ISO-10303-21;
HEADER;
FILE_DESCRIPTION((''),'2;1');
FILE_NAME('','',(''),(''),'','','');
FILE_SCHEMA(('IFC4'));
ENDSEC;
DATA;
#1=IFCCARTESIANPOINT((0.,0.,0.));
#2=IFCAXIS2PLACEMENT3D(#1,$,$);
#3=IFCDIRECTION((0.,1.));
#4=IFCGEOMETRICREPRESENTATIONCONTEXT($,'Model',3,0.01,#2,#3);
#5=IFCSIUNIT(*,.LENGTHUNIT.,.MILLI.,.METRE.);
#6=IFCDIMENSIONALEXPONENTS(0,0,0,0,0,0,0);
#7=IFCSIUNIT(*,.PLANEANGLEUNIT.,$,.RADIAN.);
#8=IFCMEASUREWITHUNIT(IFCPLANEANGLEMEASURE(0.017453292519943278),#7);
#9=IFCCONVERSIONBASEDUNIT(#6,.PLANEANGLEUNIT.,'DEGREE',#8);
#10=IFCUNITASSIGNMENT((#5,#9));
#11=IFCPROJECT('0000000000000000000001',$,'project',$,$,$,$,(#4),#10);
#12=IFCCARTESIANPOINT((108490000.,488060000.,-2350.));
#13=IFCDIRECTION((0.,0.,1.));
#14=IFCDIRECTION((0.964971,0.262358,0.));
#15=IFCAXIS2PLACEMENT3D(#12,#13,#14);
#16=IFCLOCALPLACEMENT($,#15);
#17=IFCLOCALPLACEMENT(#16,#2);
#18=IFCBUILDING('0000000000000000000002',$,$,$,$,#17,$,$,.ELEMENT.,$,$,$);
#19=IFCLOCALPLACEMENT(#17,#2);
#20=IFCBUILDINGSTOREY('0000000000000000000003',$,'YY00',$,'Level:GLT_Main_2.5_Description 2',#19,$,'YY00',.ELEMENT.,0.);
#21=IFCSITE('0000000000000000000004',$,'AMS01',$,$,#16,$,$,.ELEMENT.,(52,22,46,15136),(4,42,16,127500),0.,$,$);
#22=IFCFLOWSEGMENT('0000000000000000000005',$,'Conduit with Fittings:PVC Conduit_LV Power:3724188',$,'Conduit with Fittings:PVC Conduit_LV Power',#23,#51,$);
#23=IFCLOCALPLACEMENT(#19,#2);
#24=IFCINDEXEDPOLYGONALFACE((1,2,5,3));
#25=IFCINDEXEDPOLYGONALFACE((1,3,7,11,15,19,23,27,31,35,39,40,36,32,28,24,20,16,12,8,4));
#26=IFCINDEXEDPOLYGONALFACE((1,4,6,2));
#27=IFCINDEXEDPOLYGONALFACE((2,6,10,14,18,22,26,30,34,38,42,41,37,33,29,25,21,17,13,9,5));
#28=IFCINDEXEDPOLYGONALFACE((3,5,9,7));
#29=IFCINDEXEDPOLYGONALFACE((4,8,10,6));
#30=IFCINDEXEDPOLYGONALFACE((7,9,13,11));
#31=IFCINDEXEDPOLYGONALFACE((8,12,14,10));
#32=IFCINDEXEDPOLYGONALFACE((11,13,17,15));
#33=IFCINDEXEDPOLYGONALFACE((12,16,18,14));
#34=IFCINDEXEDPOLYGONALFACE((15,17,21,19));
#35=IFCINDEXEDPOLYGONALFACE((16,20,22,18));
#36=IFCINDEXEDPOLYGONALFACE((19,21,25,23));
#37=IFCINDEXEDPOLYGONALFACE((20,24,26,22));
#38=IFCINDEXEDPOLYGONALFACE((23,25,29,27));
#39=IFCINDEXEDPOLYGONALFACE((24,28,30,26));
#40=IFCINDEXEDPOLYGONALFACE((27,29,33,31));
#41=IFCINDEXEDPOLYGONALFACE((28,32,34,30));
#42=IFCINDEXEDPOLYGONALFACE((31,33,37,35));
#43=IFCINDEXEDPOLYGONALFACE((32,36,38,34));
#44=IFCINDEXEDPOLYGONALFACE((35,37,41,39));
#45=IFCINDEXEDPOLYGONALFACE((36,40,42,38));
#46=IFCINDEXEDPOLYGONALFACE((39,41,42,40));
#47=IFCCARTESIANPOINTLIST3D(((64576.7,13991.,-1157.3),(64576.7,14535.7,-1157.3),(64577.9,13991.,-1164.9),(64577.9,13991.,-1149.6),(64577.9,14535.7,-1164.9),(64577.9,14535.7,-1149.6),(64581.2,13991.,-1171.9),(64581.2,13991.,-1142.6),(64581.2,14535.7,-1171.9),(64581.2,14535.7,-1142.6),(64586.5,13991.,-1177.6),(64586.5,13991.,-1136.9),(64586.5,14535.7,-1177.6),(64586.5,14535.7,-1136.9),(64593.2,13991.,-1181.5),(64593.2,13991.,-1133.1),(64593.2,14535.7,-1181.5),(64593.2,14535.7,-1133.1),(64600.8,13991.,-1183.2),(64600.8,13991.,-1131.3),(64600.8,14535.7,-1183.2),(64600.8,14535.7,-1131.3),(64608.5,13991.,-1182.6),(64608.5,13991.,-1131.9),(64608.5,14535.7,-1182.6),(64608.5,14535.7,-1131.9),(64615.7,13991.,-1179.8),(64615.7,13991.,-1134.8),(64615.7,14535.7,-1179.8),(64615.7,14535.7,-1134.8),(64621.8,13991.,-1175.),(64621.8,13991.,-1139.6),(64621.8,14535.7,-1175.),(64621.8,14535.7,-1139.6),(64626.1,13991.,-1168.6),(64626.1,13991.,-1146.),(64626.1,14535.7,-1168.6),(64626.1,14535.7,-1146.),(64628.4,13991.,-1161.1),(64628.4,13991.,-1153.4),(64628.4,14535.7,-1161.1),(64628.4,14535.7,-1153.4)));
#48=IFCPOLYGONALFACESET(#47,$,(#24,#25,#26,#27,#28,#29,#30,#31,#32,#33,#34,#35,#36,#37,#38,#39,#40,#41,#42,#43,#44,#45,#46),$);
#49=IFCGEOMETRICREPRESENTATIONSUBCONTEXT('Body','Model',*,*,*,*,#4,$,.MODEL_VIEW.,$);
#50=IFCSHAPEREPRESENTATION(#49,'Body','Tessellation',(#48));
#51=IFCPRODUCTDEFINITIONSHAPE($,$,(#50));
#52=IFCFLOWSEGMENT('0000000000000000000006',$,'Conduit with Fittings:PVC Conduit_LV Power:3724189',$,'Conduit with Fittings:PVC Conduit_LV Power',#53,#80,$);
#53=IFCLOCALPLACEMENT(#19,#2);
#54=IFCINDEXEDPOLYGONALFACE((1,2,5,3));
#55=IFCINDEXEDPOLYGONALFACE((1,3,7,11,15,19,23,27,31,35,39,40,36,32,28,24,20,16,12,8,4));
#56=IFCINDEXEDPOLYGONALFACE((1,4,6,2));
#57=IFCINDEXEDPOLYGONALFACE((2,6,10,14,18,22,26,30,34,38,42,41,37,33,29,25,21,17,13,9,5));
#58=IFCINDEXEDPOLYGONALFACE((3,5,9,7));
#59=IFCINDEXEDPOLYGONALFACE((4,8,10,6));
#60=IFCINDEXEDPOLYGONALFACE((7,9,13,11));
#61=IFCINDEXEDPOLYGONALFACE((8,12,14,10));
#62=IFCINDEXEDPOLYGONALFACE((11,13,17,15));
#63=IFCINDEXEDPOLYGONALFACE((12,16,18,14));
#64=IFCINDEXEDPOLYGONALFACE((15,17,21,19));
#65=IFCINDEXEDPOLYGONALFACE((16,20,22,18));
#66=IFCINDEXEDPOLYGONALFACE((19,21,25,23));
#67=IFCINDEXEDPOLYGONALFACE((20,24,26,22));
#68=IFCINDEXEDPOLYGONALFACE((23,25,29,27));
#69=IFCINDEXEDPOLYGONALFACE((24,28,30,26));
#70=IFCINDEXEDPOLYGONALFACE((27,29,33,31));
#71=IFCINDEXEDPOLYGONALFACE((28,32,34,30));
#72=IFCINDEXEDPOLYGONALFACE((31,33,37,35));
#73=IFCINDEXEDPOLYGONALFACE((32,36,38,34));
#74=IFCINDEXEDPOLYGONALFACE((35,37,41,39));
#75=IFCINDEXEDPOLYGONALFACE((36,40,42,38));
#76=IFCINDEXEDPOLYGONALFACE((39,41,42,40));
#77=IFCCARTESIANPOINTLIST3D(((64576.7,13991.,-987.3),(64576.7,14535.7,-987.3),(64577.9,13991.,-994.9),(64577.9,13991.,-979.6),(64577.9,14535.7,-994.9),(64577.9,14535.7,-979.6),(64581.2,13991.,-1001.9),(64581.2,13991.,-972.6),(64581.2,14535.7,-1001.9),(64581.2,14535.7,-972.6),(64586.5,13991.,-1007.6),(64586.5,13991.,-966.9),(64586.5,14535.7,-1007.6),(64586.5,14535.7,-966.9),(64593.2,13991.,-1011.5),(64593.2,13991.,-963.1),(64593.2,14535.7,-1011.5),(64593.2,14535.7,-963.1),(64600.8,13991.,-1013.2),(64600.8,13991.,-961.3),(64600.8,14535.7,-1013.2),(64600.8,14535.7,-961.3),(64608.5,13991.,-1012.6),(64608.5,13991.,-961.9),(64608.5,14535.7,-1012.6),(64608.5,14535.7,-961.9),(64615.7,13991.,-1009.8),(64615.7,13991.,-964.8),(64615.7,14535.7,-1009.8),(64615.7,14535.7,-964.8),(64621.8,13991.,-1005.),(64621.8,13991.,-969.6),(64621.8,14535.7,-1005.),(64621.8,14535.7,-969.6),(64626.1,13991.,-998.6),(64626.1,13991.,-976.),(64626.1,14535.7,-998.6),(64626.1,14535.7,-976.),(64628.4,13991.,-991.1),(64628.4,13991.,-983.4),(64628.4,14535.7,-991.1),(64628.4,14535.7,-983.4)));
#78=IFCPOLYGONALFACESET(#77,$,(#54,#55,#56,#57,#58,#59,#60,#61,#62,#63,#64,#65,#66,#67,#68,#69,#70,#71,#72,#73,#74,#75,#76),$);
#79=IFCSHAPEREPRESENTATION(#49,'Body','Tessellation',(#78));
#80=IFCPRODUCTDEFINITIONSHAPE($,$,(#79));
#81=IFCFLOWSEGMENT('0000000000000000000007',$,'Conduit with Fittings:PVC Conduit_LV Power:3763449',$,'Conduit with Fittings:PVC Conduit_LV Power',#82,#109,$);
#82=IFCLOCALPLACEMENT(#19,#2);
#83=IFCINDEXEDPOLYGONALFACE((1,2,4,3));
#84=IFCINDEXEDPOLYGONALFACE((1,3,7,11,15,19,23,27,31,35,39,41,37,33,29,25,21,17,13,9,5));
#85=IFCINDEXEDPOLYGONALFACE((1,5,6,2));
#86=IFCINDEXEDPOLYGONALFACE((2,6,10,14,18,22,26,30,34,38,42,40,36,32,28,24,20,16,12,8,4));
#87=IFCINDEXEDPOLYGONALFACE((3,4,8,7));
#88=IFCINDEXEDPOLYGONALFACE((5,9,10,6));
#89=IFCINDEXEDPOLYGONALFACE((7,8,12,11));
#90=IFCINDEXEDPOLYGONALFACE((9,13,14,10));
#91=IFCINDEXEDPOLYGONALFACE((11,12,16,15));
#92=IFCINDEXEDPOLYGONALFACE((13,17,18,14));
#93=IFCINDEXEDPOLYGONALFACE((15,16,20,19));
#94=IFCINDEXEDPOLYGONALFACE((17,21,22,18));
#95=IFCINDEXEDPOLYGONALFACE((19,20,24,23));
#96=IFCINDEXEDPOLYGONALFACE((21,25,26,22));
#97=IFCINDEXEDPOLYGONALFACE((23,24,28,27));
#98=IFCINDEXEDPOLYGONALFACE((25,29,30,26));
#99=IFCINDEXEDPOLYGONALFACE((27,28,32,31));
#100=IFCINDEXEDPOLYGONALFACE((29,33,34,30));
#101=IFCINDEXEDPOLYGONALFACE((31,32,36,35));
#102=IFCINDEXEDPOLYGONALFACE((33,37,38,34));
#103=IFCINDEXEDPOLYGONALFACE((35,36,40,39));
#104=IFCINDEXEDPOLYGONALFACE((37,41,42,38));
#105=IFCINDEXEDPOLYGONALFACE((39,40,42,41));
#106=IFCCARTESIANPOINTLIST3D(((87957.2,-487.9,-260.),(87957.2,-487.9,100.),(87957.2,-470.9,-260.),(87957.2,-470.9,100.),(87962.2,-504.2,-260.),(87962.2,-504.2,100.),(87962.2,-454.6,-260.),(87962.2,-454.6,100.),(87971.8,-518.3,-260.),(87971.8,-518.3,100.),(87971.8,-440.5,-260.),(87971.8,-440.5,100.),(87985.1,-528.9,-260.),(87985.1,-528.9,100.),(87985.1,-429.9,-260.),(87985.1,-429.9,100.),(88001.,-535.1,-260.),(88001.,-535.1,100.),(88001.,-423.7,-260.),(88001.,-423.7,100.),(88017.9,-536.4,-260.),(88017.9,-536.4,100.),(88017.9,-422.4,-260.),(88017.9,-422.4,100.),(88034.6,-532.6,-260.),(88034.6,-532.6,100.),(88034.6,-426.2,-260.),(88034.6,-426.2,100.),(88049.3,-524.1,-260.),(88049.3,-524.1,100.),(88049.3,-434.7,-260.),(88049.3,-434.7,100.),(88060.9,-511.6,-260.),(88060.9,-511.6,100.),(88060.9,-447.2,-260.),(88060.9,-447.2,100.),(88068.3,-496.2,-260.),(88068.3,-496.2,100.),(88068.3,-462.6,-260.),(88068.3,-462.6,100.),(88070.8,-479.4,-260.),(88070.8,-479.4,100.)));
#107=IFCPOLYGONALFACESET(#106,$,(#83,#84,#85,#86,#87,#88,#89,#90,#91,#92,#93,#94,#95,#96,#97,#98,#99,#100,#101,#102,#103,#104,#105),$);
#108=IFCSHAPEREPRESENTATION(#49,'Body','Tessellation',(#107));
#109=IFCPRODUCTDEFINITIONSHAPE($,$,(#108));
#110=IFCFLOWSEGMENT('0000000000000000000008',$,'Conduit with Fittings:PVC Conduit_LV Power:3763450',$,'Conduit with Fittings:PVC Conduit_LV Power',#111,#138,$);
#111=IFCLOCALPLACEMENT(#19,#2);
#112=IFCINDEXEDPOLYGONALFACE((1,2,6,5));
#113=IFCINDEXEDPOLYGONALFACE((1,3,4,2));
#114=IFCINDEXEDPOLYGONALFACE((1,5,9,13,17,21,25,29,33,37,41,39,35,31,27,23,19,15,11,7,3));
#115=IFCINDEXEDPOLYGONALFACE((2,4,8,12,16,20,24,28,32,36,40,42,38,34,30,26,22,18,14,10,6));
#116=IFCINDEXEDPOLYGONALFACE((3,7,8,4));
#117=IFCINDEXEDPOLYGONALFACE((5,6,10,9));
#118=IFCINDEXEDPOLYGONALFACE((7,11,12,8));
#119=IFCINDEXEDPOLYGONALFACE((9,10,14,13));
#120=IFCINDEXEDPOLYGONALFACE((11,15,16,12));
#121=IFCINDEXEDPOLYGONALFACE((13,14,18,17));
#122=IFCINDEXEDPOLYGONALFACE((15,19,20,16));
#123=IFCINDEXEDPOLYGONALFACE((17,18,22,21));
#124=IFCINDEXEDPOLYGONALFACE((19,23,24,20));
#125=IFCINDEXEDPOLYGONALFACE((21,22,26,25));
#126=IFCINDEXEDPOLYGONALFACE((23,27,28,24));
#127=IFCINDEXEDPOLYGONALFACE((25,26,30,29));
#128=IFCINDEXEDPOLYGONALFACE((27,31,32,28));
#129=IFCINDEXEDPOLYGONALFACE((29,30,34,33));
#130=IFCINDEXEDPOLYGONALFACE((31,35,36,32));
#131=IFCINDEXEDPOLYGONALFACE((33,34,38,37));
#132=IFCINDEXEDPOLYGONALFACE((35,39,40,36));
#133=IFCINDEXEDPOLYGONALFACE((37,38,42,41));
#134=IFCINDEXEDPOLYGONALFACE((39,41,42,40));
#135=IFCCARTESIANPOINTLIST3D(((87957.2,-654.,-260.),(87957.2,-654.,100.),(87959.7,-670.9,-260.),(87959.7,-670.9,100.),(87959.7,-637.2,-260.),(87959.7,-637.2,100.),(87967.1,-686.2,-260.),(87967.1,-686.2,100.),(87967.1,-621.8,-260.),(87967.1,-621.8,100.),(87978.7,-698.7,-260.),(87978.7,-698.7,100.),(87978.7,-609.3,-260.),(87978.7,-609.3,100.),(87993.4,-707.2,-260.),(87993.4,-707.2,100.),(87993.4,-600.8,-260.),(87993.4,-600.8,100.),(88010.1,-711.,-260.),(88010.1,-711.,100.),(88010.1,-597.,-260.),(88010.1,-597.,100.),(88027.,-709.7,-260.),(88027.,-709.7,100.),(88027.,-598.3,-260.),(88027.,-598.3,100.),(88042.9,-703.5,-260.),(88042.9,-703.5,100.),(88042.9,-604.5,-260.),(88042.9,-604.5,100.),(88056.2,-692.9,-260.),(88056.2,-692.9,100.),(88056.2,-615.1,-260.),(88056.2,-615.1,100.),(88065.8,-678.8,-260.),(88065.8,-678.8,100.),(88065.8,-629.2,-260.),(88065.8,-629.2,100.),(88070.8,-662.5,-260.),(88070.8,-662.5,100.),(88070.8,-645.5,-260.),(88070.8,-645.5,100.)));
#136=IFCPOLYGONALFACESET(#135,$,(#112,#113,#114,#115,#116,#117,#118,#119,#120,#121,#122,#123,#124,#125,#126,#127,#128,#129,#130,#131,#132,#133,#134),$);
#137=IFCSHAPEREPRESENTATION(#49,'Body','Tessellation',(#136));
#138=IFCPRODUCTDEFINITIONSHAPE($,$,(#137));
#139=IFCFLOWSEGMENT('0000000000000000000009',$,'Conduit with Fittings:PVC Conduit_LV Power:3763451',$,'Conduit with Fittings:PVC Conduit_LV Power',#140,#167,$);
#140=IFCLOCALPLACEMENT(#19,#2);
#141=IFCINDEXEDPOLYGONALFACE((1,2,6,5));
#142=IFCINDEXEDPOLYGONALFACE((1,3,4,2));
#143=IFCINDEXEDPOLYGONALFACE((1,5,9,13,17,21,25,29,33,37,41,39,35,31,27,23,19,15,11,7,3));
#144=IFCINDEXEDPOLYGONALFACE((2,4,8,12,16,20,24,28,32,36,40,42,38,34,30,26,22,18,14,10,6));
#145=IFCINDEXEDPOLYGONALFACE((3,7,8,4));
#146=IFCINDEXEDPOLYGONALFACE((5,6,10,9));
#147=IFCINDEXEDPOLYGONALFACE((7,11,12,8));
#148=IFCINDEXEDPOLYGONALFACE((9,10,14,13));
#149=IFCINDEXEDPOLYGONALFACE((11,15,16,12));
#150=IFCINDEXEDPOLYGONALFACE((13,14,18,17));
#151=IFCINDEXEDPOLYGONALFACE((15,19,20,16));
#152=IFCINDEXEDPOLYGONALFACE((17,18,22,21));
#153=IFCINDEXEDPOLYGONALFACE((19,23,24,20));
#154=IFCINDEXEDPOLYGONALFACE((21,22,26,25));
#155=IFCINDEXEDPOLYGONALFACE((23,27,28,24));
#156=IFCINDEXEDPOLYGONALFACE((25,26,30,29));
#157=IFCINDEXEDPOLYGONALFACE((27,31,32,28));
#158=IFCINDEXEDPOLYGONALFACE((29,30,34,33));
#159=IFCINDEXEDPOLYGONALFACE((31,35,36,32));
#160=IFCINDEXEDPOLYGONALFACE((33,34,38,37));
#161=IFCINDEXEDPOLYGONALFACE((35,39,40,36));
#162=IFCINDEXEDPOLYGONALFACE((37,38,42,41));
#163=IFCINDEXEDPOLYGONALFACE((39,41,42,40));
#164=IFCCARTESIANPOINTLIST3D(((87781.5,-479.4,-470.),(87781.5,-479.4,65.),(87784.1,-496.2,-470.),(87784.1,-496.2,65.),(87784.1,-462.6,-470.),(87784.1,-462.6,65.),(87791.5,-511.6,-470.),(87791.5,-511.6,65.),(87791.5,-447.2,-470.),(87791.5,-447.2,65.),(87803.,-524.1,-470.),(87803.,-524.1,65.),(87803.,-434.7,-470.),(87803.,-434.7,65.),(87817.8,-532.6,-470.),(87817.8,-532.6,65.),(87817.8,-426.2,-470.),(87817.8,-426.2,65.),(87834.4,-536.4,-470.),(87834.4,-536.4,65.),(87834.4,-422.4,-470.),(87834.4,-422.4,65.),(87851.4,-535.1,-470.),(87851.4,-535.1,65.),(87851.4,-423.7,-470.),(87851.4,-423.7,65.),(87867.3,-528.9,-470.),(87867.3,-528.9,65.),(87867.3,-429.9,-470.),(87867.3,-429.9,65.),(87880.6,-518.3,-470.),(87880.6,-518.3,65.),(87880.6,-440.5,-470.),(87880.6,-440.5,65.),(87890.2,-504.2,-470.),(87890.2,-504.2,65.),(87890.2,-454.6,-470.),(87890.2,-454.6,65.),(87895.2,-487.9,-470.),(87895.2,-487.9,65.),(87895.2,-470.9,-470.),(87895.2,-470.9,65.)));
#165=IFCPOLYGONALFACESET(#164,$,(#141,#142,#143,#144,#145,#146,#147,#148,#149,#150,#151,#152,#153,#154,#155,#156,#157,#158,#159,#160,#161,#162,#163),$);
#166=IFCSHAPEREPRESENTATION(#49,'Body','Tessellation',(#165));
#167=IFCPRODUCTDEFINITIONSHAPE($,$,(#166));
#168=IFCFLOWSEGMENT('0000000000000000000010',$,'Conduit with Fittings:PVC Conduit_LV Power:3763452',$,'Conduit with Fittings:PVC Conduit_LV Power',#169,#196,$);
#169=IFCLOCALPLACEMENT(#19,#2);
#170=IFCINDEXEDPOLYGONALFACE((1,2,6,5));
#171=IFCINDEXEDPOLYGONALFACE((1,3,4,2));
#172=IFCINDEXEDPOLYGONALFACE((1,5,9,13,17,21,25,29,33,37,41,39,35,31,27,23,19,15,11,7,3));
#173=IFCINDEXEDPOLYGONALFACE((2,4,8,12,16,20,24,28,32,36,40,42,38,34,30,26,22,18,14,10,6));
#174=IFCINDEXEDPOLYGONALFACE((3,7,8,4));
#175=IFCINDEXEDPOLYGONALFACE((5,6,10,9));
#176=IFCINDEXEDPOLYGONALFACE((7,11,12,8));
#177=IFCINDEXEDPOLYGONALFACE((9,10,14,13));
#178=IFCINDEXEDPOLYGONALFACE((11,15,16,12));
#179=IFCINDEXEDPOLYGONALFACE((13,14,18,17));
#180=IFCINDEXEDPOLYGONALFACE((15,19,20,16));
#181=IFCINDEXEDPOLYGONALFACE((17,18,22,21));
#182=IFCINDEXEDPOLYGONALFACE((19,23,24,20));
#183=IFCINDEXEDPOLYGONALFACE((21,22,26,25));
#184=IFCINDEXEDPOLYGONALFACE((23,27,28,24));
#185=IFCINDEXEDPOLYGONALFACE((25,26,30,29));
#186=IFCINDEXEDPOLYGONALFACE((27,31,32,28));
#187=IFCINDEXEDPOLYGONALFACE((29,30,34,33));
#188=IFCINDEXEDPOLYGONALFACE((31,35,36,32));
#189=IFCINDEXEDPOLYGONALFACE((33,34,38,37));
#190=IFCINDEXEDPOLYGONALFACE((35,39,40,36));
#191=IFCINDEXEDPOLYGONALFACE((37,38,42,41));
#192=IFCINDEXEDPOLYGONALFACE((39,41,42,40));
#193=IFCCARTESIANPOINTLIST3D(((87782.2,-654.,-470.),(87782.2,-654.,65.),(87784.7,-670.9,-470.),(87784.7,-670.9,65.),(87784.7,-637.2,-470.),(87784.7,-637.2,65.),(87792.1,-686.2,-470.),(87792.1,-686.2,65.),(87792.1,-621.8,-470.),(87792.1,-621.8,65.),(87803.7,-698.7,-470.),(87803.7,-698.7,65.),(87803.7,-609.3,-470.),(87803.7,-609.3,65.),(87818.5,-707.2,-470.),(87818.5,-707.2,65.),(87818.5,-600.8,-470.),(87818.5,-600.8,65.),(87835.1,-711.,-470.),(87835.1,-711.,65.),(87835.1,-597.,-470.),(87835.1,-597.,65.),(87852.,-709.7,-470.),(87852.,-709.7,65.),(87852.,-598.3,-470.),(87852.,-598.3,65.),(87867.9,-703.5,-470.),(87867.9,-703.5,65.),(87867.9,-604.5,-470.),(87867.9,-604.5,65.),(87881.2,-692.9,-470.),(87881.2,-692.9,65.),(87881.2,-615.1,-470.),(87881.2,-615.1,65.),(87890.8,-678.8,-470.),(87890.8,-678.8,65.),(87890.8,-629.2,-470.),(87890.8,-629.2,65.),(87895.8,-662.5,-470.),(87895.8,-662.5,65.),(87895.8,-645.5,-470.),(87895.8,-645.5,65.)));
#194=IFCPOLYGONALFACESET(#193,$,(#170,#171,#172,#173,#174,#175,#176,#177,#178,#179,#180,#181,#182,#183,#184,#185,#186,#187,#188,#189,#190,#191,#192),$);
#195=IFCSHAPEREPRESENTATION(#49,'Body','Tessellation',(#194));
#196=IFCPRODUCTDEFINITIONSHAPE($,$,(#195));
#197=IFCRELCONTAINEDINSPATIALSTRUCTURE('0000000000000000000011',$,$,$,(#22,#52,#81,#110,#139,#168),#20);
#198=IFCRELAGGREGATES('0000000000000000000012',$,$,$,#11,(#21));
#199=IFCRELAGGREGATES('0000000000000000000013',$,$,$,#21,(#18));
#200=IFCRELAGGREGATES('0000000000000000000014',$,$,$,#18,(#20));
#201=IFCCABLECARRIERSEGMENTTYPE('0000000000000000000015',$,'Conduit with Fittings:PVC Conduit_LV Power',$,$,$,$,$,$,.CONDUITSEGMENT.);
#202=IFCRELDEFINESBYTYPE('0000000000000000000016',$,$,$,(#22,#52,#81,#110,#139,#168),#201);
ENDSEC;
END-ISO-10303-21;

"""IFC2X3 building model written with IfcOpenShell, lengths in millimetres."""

from ifc_helpers import new_model, entity, si_unit, converted_unit, direction, frame, frame_2d, origin, origin_2d_with_axis, place, context, subcontext, project, spatial, circle, extrude, type_object, element, save


model = new_model("IFC2X3")

# Units and contexts
model_context = context("Model", 3, precision=0.01, world=origin(), true_north=direction((0.0, 1.0)))
body_context = subcontext(model_context, "Body", "Model", "MODEL_VIEW")
ifc_project = project(units=[si_unit("LENGTHUNIT", "METRE", prefix="MILLI"), converted_unit("PLANEANGLEUNIT", "DEGREE", entity("IfcPlaneAngleMeasure", 0.017453292519943278), si_unit("PLANEANGLEUNIT", "RADIAN"), dimensions=[0, 0, 0, 0, 0, 0, 0])], contexts=[model_context])

# Site, building, storey
site_placement = place(None, frame((108490000.0, 488060000.0, -2350.0), z_axis=(0.0, 0.0, 1.0), x_axis=(0.964971, 0.262358, 0.0)))
site = spatial("IfcSite", under=ifc_project, at=site_placement, Name="AMS01", CompositionType="ELEMENT", RefLatitude=(52, 22, 46, 15136), RefLongitude=(4, 42, 16, 127500), RefElevation=0.0)
building_placement = place(site_placement, origin())
building = spatial("IfcBuilding", under=site, at=building_placement, CompositionType="ELEMENT")
storey_placement = place(building_placement, origin())
storey = spatial("IfcBuildingStorey", under=building, at=storey_placement, Name="YY00", ObjectType="Level:GLT_Main_2.5_Description 2", LongName="YY00", CompositionType="ELEMENT", Elevation=0.0)

# Flow segments
cable_carrier_segment_type = type_object("IfcCableCarrierSegmentType", Name="Conduit with Fittings:PVC Conduit_LV Power", PredefinedType="CONDUITSEGMENT")
flow_segment_1_placement = place(storey_placement, origin())
element("IfcFlowSegment", 1, at=flow_segment_1_placement, inside=storey, type_object=cable_carrier_segment_type, Name="Conduit with Fittings:PVC Conduit_LV Power:3724188", ObjectType="Conduit with Fittings:PVC Conduit_LV Power", context=body_context, shape_type="SweptSolid", body=[
    extrude(circle(Radius=26.0, at=frame_2d((0.0, 0.0), x_axis=(1.0, 0.0))), frame((64602.7, 13991.0, -1157.3), z_axis=(0.0, 1.0, 0.0), x_axis=(-1.0, 0.0, 0.0)), (0.0, 0.0, 1.0), 544.6),
])
flow_segment_2_placement = place(storey_placement, origin())
element("IfcFlowSegment", 2, at=flow_segment_2_placement, inside=storey, type_object=cable_carrier_segment_type, Name="Conduit with Fittings:PVC Conduit_LV Power:3724189", ObjectType="Conduit with Fittings:PVC Conduit_LV Power", context=body_context, shape_type="SweptSolid", body=[
    extrude(circle(Radius=26.0, at=origin_2d_with_axis()), frame((64602.7, 13991.0, -987.3), z_axis=(0.0, 1.0, 0.0), x_axis=(-1.0, 0.0, 0.0)), (0.0, 0.0, 1.0), 544.6),
])
flow_segment_3_placement = place(storey_placement, origin())
element("IfcFlowSegment", 3, at=flow_segment_3_placement, inside=storey, type_object=cable_carrier_segment_type, Name="Conduit with Fittings:PVC Conduit_LV Power:3763449", ObjectType="Conduit with Fittings:PVC Conduit_LV Power", context=body_context, shape_type="SweptSolid", body=[
    extrude(circle(Radius=57.2, at=frame_2d((0.0, 0.0), x_axis=(1.0, 0.0))), frame((88013.7, -479.4, -260.0)), (0.0, 0.0, 1.0), 360.0),
])
flow_segment_4_placement = place(storey_placement, origin())
element("IfcFlowSegment", 4, at=flow_segment_4_placement, inside=storey, type_object=cable_carrier_segment_type, Name="Conduit with Fittings:PVC Conduit_LV Power:3763450", ObjectType="Conduit with Fittings:PVC Conduit_LV Power", context=body_context, shape_type="SweptSolid", body=[
    extrude(circle(Radius=57.2, at=frame_2d((0.0, 0.0), x_axis=(1.0, 0.0))), frame((88014.3, -654.0, -260.0), z_axis=(0.0, 0.000001, 1.0), x_axis=(-1.0, 0.0, 0.0)), (0.0, 0.0, 1.0), 360.0),
])
flow_segment_5_placement = place(storey_placement, origin())
element("IfcFlowSegment", 5, at=flow_segment_5_placement, inside=storey, type_object=cable_carrier_segment_type, Name="Conduit with Fittings:PVC Conduit_LV Power:3763451", ObjectType="Conduit with Fittings:PVC Conduit_LV Power", context=body_context, shape_type="SweptSolid", body=[
    extrude(circle(Radius=57.2, at=origin_2d_with_axis()), frame((87838.7, -479.4, -470.0), z_axis=(0.0, 0.0, 1.0), x_axis=(-1.0, 0.0, 0.0)), (0.0, 0.0, 1.0), 535.0),
])
flow_segment_6_placement = place(storey_placement, origin())
element("IfcFlowSegment", 6, at=flow_segment_6_placement, inside=storey, type_object=cable_carrier_segment_type, Name="Conduit with Fittings:PVC Conduit_LV Power:3763452", ObjectType="Conduit with Fittings:PVC Conduit_LV Power", context=body_context, shape_type="SweptSolid", body=[
    extrude(circle(Radius=57.2, at=frame_2d((0.0, 0.0), x_axis=(1.0, 0.0))), frame((87839.3, -654.0, -470.0), z_axis=(0.0, 0.0, 1.0), x_axis=(-1.0, 0.0, 0.0)), (0.0, 0.0, 1.0), 535.0),
])

save(model, "model.ifc")
